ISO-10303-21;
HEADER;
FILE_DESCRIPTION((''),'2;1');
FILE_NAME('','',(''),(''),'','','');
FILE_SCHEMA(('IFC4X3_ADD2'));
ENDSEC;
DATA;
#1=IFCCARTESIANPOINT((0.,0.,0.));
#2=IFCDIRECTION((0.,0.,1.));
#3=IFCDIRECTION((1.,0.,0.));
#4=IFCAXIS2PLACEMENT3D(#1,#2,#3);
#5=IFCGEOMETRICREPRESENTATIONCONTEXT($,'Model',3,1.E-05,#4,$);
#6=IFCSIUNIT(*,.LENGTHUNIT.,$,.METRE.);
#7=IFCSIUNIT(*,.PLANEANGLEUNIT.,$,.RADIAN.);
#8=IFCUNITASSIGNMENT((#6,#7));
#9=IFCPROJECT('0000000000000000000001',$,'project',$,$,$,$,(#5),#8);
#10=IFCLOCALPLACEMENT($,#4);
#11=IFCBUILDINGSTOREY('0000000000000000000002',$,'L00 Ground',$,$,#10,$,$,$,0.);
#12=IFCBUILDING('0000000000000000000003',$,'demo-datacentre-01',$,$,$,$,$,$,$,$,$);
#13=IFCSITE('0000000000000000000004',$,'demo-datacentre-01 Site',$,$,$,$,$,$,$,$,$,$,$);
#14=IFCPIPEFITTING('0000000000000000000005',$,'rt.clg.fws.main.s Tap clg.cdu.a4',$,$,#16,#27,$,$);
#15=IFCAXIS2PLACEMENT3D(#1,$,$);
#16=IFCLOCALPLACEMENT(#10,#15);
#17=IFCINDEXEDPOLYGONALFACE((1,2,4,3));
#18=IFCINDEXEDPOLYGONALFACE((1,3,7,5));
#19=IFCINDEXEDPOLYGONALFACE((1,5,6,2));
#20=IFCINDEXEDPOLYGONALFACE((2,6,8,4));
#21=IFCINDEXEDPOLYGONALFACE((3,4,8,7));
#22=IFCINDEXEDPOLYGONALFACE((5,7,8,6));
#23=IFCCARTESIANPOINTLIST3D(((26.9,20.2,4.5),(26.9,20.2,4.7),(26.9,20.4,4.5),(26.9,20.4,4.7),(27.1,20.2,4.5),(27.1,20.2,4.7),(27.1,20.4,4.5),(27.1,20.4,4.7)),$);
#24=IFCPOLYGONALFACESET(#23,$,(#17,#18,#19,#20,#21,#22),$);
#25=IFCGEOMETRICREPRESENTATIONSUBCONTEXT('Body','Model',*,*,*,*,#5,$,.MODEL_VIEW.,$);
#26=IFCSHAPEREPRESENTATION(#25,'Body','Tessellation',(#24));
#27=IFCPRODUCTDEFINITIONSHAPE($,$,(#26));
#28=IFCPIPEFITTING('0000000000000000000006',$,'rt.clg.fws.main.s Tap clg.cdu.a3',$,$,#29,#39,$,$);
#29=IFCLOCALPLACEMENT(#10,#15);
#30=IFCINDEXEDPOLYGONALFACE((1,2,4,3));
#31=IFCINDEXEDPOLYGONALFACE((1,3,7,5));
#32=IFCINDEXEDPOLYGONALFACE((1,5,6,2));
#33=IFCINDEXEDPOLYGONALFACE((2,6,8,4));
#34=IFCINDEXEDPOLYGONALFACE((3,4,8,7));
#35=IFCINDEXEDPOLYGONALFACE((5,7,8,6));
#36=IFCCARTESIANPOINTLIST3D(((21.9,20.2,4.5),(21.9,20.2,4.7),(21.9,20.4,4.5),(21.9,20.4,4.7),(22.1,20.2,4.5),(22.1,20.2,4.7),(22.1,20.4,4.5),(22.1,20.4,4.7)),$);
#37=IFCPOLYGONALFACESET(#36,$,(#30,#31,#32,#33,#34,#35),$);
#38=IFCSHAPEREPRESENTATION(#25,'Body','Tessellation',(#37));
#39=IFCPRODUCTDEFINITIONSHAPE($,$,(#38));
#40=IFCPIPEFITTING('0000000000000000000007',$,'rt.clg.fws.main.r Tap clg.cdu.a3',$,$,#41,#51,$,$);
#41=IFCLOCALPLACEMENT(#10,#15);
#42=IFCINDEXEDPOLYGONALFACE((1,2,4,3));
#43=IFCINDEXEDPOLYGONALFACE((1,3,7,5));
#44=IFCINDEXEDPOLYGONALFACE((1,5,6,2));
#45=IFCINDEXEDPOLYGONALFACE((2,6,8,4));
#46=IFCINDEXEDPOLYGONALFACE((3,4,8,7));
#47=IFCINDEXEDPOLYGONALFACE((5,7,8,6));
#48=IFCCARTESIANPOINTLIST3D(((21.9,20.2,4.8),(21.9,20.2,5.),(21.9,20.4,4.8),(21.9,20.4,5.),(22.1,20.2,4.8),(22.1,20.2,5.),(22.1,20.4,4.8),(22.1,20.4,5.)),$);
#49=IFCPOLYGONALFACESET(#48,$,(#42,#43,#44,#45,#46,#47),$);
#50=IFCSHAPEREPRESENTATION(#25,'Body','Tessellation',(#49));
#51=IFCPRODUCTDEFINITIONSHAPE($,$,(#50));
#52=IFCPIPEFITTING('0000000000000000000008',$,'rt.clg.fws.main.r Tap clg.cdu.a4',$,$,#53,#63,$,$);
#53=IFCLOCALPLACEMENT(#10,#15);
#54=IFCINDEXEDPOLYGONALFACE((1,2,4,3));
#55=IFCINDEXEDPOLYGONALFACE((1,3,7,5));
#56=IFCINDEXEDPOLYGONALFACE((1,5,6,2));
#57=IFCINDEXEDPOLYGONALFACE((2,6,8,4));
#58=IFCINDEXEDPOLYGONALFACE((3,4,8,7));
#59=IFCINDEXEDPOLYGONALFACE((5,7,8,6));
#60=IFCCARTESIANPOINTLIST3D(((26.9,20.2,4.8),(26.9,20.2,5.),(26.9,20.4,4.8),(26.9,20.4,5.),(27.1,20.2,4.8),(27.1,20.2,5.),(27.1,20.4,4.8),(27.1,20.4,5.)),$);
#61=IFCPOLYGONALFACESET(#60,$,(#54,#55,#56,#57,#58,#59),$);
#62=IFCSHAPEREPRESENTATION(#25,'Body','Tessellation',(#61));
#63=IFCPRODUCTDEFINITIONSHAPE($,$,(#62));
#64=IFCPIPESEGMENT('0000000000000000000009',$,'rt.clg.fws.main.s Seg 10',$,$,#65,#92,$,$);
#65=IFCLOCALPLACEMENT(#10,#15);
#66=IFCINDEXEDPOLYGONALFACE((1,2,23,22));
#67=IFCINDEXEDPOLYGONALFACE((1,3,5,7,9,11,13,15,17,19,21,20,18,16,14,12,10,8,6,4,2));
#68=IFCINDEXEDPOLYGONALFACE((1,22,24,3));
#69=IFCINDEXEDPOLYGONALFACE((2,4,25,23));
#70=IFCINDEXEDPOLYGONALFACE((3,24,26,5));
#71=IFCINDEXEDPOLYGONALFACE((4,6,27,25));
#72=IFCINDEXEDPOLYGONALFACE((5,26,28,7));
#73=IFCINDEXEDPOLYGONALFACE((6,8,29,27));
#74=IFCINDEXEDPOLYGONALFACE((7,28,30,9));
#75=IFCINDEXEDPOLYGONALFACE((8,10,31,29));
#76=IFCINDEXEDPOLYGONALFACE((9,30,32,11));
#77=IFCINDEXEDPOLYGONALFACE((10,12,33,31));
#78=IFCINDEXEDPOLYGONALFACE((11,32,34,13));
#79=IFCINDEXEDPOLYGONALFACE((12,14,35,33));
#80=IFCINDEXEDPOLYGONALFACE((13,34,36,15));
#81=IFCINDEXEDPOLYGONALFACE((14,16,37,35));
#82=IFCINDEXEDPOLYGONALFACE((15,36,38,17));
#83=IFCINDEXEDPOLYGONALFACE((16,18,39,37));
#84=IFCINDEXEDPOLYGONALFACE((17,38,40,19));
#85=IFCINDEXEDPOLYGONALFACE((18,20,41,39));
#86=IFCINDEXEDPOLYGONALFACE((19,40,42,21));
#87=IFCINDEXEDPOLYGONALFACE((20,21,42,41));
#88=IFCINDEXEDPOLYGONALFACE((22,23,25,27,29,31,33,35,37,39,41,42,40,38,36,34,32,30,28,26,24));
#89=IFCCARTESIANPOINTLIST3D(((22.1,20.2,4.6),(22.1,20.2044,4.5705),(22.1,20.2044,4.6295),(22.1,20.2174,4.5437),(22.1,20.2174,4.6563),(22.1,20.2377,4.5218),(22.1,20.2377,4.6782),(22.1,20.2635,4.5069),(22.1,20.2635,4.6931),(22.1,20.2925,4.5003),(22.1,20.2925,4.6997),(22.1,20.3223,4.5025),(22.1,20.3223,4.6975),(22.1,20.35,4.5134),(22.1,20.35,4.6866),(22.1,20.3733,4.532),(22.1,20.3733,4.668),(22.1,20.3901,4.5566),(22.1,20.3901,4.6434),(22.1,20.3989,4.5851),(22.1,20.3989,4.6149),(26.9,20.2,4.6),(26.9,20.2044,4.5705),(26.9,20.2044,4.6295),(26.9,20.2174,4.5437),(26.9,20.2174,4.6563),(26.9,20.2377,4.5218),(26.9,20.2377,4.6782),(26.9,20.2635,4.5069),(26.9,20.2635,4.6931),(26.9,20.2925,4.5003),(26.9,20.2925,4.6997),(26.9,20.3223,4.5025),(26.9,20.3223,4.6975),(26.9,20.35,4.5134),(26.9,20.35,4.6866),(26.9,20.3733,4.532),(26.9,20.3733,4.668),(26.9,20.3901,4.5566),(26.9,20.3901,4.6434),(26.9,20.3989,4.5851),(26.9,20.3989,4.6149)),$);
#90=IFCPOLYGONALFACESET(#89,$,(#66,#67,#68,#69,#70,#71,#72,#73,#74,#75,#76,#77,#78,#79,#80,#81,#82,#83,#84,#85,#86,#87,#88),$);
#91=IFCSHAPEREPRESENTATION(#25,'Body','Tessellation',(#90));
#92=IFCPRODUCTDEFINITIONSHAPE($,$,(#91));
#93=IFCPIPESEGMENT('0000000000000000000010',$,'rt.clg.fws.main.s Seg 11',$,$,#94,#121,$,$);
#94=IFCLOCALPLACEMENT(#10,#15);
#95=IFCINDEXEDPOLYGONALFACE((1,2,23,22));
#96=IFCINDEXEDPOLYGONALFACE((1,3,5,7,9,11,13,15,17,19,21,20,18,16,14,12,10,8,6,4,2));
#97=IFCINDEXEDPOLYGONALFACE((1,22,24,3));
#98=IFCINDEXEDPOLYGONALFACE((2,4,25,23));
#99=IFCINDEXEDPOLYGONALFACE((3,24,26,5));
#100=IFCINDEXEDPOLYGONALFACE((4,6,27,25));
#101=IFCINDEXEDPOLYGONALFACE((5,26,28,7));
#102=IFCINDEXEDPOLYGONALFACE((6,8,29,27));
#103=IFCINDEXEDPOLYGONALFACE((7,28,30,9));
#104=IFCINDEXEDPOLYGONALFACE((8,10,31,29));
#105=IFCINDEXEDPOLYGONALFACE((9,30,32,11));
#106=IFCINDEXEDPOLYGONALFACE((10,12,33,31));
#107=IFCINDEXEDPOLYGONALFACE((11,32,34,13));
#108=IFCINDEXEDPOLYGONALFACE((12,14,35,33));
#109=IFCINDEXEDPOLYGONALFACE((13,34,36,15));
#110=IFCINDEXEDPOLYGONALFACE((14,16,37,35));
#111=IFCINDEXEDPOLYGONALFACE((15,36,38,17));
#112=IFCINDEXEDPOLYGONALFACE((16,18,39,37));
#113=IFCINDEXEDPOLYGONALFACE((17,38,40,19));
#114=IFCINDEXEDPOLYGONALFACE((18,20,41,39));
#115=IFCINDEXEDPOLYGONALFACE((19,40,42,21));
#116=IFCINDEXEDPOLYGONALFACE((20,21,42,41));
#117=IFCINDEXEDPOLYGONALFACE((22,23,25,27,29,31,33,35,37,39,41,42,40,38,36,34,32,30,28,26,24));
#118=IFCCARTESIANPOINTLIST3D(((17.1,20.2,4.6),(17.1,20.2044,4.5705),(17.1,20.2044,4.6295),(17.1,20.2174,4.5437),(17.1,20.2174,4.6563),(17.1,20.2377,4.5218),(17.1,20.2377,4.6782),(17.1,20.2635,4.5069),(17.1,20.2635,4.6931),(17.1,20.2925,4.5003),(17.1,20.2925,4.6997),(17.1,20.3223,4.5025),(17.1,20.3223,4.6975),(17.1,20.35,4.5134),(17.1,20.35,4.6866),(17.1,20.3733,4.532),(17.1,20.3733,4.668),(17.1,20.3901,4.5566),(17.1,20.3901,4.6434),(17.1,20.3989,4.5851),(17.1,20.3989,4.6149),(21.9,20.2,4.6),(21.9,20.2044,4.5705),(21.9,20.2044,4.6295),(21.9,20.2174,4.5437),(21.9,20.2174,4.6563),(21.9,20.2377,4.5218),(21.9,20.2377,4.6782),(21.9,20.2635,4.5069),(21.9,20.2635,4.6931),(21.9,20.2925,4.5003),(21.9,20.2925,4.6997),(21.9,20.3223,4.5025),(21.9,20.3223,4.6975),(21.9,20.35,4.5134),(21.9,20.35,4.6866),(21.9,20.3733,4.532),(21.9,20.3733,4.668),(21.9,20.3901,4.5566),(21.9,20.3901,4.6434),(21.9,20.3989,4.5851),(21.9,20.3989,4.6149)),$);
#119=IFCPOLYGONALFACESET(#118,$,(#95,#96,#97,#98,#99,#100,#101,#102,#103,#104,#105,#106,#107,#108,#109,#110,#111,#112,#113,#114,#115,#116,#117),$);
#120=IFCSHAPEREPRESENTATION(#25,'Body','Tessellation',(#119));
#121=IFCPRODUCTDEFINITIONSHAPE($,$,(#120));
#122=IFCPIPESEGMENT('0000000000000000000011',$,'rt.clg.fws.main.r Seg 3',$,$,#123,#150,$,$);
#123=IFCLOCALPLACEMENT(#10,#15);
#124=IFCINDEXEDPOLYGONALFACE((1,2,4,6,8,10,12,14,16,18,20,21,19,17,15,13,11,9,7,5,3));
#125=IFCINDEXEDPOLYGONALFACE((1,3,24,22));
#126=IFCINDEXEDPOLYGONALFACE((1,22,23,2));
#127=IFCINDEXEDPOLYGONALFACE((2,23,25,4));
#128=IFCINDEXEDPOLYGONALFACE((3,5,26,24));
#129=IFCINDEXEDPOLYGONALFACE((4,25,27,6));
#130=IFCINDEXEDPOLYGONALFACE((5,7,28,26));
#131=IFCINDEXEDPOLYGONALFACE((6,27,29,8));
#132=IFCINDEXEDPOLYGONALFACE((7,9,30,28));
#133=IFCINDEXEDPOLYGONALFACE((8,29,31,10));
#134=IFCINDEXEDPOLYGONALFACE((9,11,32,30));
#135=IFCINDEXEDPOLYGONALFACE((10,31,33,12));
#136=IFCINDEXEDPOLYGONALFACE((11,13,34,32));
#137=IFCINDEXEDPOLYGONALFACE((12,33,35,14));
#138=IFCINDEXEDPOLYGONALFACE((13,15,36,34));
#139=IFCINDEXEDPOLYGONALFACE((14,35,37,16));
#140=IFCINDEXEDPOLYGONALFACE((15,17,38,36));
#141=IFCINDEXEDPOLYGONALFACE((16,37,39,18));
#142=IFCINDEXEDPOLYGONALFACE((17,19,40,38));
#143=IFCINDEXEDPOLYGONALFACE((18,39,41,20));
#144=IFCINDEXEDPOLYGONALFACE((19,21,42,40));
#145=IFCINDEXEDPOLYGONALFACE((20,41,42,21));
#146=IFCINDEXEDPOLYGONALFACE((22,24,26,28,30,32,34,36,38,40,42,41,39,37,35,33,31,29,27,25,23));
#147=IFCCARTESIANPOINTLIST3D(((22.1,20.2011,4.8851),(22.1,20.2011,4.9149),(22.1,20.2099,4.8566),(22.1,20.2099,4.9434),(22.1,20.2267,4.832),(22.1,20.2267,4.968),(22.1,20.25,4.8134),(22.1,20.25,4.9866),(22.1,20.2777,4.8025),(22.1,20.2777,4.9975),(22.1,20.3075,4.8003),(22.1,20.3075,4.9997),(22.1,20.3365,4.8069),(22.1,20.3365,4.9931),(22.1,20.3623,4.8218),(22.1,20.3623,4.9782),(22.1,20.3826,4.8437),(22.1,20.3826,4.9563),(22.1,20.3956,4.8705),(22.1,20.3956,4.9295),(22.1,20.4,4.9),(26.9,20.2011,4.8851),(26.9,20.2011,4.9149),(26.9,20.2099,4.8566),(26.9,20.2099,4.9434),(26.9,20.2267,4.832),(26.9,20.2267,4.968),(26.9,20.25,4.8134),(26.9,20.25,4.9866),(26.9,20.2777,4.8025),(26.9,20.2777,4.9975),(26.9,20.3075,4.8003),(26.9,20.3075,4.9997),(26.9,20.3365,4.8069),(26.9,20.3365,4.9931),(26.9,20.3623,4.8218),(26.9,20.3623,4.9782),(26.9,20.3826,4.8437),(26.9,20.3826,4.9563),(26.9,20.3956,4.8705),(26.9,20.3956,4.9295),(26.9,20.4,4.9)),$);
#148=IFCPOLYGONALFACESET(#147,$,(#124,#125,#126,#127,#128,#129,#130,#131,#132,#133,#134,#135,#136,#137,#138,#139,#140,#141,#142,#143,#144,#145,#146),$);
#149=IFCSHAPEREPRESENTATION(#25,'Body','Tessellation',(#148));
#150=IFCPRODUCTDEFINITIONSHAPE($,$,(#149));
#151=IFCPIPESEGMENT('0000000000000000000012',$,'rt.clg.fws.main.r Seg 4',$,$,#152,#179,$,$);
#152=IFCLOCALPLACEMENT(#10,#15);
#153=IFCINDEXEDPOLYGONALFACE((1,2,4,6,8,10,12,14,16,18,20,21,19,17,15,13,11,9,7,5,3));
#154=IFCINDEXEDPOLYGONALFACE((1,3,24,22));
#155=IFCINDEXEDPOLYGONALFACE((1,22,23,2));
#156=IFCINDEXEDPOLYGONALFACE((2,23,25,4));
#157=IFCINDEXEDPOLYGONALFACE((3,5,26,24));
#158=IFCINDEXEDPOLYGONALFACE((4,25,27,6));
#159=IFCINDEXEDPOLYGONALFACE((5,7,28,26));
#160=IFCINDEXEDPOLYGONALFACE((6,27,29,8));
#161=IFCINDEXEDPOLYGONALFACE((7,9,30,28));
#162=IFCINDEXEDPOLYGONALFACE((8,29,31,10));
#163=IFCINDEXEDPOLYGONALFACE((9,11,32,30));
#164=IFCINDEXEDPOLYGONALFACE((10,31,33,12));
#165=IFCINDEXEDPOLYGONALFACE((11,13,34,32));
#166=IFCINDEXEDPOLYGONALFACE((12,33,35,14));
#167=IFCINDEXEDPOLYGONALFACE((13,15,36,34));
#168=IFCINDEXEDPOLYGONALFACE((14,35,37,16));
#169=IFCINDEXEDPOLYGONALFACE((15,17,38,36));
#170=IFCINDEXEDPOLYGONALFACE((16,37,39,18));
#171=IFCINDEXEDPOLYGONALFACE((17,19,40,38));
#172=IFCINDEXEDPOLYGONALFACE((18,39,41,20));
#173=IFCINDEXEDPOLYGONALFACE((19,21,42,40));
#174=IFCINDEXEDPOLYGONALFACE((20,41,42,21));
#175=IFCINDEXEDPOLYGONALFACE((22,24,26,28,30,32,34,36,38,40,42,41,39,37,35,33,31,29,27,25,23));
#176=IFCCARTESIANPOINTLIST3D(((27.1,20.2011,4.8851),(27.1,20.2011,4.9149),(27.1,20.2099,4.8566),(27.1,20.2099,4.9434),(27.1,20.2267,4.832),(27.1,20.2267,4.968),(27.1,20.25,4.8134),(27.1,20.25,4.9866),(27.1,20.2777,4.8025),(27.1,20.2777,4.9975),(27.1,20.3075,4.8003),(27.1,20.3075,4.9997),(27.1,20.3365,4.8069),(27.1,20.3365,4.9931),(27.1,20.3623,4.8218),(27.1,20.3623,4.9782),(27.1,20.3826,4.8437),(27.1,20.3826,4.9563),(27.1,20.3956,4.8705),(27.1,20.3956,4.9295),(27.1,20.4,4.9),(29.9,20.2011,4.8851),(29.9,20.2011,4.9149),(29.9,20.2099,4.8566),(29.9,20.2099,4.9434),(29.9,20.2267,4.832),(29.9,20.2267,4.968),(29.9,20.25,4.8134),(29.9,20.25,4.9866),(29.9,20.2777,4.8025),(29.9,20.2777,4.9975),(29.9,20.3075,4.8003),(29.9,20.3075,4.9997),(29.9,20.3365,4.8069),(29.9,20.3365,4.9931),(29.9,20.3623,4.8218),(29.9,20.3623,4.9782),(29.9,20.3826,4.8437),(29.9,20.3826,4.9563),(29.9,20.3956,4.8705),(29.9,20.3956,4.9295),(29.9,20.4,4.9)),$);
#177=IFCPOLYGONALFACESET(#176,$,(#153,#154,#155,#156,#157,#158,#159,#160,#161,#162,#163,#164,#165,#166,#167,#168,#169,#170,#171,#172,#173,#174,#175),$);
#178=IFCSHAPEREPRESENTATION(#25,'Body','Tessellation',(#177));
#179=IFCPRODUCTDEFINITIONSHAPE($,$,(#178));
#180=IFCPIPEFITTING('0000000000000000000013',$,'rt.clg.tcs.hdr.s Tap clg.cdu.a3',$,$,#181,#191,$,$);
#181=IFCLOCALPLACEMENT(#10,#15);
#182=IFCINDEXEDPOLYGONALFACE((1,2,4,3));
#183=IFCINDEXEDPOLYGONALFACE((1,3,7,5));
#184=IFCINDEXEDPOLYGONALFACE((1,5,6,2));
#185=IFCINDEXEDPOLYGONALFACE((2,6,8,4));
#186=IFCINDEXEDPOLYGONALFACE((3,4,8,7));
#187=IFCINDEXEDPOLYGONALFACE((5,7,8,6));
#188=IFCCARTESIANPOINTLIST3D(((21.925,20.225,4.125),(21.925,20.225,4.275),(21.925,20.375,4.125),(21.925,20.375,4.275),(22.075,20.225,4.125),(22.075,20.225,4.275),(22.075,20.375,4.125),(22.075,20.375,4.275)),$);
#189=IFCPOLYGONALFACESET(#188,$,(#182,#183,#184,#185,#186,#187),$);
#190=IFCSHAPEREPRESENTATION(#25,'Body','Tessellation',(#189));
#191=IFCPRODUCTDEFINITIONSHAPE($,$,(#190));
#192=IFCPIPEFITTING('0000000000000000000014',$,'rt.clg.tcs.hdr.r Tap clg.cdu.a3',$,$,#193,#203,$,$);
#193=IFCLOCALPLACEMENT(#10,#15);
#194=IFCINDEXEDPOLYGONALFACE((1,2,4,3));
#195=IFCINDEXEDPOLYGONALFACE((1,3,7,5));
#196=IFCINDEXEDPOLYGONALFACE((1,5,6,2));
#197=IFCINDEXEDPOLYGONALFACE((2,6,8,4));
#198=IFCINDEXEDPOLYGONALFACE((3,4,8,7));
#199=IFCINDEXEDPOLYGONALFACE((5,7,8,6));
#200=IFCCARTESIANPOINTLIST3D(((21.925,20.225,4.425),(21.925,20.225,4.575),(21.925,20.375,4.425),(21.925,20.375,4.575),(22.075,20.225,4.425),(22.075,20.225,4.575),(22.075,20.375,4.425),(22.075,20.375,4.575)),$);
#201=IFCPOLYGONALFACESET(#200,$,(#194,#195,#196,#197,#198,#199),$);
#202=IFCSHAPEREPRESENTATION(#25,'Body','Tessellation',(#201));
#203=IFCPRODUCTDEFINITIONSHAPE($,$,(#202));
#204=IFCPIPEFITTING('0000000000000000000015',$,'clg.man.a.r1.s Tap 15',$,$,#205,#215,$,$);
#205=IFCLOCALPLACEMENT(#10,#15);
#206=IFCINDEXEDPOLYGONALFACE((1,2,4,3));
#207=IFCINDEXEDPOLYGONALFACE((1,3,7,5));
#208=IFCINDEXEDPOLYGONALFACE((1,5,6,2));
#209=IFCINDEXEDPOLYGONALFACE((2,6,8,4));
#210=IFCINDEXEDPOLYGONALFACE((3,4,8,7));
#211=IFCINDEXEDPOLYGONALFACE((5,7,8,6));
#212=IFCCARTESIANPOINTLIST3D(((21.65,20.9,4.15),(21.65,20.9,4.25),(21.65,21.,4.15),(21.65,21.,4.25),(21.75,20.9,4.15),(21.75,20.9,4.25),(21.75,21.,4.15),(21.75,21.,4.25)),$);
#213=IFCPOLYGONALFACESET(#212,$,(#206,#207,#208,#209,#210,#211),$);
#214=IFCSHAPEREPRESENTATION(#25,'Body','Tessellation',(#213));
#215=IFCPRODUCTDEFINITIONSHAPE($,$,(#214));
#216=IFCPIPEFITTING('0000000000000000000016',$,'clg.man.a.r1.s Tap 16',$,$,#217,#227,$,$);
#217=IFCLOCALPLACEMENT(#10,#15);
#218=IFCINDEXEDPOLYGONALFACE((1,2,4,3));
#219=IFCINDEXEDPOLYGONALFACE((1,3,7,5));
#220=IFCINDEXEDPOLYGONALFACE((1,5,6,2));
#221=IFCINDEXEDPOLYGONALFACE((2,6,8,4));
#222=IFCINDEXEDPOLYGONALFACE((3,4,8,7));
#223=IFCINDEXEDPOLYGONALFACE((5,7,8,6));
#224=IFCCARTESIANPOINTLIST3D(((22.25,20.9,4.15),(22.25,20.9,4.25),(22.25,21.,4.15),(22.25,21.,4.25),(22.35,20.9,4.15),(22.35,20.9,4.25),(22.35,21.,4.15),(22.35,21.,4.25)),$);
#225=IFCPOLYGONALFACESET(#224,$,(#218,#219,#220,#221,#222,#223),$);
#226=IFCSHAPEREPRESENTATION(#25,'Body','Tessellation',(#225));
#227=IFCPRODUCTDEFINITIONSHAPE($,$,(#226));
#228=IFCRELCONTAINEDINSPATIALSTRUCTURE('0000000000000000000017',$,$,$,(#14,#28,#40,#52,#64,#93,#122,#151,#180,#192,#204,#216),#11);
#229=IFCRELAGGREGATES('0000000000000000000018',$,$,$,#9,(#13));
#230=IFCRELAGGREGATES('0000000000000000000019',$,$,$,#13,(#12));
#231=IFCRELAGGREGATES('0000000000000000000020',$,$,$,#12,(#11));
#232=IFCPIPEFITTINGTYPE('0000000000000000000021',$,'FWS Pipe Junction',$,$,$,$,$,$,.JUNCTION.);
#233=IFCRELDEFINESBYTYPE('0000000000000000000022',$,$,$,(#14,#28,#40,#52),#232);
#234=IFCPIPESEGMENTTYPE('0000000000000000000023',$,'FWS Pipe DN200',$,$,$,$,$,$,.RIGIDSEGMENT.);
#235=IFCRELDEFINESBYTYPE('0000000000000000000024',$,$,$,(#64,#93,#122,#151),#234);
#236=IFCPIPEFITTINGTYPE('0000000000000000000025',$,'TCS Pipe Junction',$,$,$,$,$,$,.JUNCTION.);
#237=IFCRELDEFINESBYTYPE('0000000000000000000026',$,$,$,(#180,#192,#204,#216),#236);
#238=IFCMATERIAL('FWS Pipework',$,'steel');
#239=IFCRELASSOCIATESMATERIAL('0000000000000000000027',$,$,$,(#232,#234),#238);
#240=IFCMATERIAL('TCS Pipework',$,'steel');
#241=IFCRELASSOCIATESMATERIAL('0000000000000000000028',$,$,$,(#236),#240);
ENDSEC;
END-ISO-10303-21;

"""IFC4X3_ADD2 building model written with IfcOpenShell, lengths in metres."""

from ifc_helpers import new_model, si_unit, frame, origin_with_axes, place, context, subcontext, project, spatial, rectangle, circle, extrude, material, type_object, element, save


model = new_model("IFC4X3_ADD2")

# Units and contexts
model_context = context("Model", 3, precision=1e-05, world=origin_with_axes())
body_context = subcontext(model_context, "Body", "Model", "MODEL_VIEW")
ifc_project = project(units=[si_unit("LENGTHUNIT", "METRE"), si_unit("PLANEANGLEUNIT", "RADIAN")], contexts=[model_context])

# Site, building, storey
site = spatial("IfcSite", under=ifc_project, Name="demo-datacentre-01 Site")
building = spatial("IfcBuilding", under=site, Name="demo-datacentre-01")
storey_placement = place(None, origin_with_axes())
storey = spatial("IfcBuildingStorey", under=building, at=storey_placement, Name="L00 Ground", Elevation=0.0)

# Pipe fittings
ifc_material_1 = material(Name="FWS Pipework", Category="steel")
pipe_fitting_type_1 = type_object("IfcPipeFittingType", Name="FWS Pipe Junction", PredefinedType="JUNCTION", material=ifc_material_1)
for number, where, z_axis, x_axis, name in (
    (1, (27.0, 20.3, 4.5), (0.0, 0.0, 1.0), (1.0, 0.0, 0.0), "rt.clg.fws.main.s Tap clg.cdu.a4"),
    (2, (22.0, 20.3, 4.5), (0.0, 0.0, 1.0), (1.0, 0.0, 0.0), "rt.clg.fws.main.s Tap clg.cdu.a3"),
    (3, (22.0, 20.3, 4.8), (0.0, 0.0, 1.0), (1.0, 0.0, 0.0), "rt.clg.fws.main.r Tap clg.cdu.a3"),
    (4, (27.0, 20.3, 4.8), (0.0, 0.0, 1.0), (1.0, 0.0, 0.0), "rt.clg.fws.main.r Tap clg.cdu.a4"),
):
    element("IfcPipeFitting", number, at=place(storey_placement, frame(where, z_axis=z_axis, x_axis=x_axis)), inside=storey, type_object=pipe_fitting_type_1, Name=name, context=body_context, shape_type="SweptSolid", body=[
        extrude(rectangle(XDim=0.2, YDim=0.2), origin_with_axes(), (0.0, 0.0, 1.0), 0.2),
    ])

# Pipe segments
pipe_segment_type_1 = type_object("IfcPipeSegmentType", Name="FWS Pipe DN200", PredefinedType="RIGIDSEGMENT", material=ifc_material_1)
for number, where, z_axis, x_axis, name in (
    (5, (26.9, 20.3, 4.6), (-1.0, 0.0, 0.0), (0.0, -1.0, 0.0), "rt.clg.fws.main.s Seg 10"),
    (6, (21.9, 20.3, 4.6), (-1.0, 0.0, 0.0), (0.0, -1.0, 0.0), "rt.clg.fws.main.s Seg 11"),
    (7, (22.1, 20.3, 4.9), (1.0, 0.0, 0.0), (0.0, 1.0, 0.0), "rt.clg.fws.main.r Seg 3"),
):
    element("IfcPipeSegment", number, at=place(storey_placement, frame(where, z_axis=z_axis, x_axis=x_axis)), inside=storey, type_object=pipe_segment_type_1, Name=name, context=body_context, shape_type="SweptSolid", body=[
        extrude(circle(Radius=0.1), origin_with_axes(), (0.0, 0.0, 1.0), 4.8),
    ])
pipe_segment_1_placement = place(storey_placement, frame((27.1, 20.3, 4.9), z_axis=(1.0, 0.0, 0.0), x_axis=(0.0, 1.0, 0.0)))
element("IfcPipeSegment", 8, at=pipe_segment_1_placement, inside=storey, type_object=pipe_segment_type_1, Name="rt.clg.fws.main.r Seg 4", context=body_context, shape_type="SweptSolid", body=[
    extrude(circle(Radius=0.1), origin_with_axes(), (0.0, 0.0, 1.0), 2.8),
])

# Pipe fittings
ifc_material_2 = material(Name="TCS Pipework", Category="steel")
pipe_fitting_type_2 = type_object("IfcPipeFittingType", Name="TCS Pipe Junction", PredefinedType="JUNCTION", material=ifc_material_2)
for number, where, z_axis, x_axis, name in (
    (9, (22.0, 20.3, 4.125), (0.0, 0.0, 1.0), (1.0, 0.0, 0.0), "rt.clg.tcs.hdr.s Tap clg.cdu.a3"),
    (10, (22.0, 20.3, 4.425), (0.0, 0.0, 1.0), (1.0, 0.0, 0.0), "rt.clg.tcs.hdr.r Tap clg.cdu.a3"),
):
    element("IfcPipeFitting", number, at=place(storey_placement, frame(where, z_axis=z_axis, x_axis=x_axis)), inside=storey, type_object=pipe_fitting_type_2, Name=name, context=body_context, shape_type="SweptSolid", body=[
        extrude(rectangle(XDim=0.15, YDim=0.15), origin_with_axes(), (0.0, 0.0, 1.0), 0.15),
    ])
for number, where, z_axis, x_axis, name in (
    (11, (21.7, 20.95, 4.15), (0.0, 0.0, 1.0), (1.0, 0.0, 0.0), "clg.man.a.r1.s Tap 15"),
    (12, (22.3, 20.95, 4.15), (0.0, 0.0, 1.0), (1.0, 0.0, 0.0), "clg.man.a.r1.s Tap 16"),
):
    element("IfcPipeFitting", number, at=place(storey_placement, frame(where, z_axis=z_axis, x_axis=x_axis)), inside=storey, type_object=pipe_fitting_type_2, Name=name, context=body_context, shape_type="SweptSolid", body=[
        extrude(rectangle(XDim=0.1, YDim=0.1), origin_with_axes(), (0.0, 0.0, 1.0), 0.1),
    ])

save(model, "model.ifc")
